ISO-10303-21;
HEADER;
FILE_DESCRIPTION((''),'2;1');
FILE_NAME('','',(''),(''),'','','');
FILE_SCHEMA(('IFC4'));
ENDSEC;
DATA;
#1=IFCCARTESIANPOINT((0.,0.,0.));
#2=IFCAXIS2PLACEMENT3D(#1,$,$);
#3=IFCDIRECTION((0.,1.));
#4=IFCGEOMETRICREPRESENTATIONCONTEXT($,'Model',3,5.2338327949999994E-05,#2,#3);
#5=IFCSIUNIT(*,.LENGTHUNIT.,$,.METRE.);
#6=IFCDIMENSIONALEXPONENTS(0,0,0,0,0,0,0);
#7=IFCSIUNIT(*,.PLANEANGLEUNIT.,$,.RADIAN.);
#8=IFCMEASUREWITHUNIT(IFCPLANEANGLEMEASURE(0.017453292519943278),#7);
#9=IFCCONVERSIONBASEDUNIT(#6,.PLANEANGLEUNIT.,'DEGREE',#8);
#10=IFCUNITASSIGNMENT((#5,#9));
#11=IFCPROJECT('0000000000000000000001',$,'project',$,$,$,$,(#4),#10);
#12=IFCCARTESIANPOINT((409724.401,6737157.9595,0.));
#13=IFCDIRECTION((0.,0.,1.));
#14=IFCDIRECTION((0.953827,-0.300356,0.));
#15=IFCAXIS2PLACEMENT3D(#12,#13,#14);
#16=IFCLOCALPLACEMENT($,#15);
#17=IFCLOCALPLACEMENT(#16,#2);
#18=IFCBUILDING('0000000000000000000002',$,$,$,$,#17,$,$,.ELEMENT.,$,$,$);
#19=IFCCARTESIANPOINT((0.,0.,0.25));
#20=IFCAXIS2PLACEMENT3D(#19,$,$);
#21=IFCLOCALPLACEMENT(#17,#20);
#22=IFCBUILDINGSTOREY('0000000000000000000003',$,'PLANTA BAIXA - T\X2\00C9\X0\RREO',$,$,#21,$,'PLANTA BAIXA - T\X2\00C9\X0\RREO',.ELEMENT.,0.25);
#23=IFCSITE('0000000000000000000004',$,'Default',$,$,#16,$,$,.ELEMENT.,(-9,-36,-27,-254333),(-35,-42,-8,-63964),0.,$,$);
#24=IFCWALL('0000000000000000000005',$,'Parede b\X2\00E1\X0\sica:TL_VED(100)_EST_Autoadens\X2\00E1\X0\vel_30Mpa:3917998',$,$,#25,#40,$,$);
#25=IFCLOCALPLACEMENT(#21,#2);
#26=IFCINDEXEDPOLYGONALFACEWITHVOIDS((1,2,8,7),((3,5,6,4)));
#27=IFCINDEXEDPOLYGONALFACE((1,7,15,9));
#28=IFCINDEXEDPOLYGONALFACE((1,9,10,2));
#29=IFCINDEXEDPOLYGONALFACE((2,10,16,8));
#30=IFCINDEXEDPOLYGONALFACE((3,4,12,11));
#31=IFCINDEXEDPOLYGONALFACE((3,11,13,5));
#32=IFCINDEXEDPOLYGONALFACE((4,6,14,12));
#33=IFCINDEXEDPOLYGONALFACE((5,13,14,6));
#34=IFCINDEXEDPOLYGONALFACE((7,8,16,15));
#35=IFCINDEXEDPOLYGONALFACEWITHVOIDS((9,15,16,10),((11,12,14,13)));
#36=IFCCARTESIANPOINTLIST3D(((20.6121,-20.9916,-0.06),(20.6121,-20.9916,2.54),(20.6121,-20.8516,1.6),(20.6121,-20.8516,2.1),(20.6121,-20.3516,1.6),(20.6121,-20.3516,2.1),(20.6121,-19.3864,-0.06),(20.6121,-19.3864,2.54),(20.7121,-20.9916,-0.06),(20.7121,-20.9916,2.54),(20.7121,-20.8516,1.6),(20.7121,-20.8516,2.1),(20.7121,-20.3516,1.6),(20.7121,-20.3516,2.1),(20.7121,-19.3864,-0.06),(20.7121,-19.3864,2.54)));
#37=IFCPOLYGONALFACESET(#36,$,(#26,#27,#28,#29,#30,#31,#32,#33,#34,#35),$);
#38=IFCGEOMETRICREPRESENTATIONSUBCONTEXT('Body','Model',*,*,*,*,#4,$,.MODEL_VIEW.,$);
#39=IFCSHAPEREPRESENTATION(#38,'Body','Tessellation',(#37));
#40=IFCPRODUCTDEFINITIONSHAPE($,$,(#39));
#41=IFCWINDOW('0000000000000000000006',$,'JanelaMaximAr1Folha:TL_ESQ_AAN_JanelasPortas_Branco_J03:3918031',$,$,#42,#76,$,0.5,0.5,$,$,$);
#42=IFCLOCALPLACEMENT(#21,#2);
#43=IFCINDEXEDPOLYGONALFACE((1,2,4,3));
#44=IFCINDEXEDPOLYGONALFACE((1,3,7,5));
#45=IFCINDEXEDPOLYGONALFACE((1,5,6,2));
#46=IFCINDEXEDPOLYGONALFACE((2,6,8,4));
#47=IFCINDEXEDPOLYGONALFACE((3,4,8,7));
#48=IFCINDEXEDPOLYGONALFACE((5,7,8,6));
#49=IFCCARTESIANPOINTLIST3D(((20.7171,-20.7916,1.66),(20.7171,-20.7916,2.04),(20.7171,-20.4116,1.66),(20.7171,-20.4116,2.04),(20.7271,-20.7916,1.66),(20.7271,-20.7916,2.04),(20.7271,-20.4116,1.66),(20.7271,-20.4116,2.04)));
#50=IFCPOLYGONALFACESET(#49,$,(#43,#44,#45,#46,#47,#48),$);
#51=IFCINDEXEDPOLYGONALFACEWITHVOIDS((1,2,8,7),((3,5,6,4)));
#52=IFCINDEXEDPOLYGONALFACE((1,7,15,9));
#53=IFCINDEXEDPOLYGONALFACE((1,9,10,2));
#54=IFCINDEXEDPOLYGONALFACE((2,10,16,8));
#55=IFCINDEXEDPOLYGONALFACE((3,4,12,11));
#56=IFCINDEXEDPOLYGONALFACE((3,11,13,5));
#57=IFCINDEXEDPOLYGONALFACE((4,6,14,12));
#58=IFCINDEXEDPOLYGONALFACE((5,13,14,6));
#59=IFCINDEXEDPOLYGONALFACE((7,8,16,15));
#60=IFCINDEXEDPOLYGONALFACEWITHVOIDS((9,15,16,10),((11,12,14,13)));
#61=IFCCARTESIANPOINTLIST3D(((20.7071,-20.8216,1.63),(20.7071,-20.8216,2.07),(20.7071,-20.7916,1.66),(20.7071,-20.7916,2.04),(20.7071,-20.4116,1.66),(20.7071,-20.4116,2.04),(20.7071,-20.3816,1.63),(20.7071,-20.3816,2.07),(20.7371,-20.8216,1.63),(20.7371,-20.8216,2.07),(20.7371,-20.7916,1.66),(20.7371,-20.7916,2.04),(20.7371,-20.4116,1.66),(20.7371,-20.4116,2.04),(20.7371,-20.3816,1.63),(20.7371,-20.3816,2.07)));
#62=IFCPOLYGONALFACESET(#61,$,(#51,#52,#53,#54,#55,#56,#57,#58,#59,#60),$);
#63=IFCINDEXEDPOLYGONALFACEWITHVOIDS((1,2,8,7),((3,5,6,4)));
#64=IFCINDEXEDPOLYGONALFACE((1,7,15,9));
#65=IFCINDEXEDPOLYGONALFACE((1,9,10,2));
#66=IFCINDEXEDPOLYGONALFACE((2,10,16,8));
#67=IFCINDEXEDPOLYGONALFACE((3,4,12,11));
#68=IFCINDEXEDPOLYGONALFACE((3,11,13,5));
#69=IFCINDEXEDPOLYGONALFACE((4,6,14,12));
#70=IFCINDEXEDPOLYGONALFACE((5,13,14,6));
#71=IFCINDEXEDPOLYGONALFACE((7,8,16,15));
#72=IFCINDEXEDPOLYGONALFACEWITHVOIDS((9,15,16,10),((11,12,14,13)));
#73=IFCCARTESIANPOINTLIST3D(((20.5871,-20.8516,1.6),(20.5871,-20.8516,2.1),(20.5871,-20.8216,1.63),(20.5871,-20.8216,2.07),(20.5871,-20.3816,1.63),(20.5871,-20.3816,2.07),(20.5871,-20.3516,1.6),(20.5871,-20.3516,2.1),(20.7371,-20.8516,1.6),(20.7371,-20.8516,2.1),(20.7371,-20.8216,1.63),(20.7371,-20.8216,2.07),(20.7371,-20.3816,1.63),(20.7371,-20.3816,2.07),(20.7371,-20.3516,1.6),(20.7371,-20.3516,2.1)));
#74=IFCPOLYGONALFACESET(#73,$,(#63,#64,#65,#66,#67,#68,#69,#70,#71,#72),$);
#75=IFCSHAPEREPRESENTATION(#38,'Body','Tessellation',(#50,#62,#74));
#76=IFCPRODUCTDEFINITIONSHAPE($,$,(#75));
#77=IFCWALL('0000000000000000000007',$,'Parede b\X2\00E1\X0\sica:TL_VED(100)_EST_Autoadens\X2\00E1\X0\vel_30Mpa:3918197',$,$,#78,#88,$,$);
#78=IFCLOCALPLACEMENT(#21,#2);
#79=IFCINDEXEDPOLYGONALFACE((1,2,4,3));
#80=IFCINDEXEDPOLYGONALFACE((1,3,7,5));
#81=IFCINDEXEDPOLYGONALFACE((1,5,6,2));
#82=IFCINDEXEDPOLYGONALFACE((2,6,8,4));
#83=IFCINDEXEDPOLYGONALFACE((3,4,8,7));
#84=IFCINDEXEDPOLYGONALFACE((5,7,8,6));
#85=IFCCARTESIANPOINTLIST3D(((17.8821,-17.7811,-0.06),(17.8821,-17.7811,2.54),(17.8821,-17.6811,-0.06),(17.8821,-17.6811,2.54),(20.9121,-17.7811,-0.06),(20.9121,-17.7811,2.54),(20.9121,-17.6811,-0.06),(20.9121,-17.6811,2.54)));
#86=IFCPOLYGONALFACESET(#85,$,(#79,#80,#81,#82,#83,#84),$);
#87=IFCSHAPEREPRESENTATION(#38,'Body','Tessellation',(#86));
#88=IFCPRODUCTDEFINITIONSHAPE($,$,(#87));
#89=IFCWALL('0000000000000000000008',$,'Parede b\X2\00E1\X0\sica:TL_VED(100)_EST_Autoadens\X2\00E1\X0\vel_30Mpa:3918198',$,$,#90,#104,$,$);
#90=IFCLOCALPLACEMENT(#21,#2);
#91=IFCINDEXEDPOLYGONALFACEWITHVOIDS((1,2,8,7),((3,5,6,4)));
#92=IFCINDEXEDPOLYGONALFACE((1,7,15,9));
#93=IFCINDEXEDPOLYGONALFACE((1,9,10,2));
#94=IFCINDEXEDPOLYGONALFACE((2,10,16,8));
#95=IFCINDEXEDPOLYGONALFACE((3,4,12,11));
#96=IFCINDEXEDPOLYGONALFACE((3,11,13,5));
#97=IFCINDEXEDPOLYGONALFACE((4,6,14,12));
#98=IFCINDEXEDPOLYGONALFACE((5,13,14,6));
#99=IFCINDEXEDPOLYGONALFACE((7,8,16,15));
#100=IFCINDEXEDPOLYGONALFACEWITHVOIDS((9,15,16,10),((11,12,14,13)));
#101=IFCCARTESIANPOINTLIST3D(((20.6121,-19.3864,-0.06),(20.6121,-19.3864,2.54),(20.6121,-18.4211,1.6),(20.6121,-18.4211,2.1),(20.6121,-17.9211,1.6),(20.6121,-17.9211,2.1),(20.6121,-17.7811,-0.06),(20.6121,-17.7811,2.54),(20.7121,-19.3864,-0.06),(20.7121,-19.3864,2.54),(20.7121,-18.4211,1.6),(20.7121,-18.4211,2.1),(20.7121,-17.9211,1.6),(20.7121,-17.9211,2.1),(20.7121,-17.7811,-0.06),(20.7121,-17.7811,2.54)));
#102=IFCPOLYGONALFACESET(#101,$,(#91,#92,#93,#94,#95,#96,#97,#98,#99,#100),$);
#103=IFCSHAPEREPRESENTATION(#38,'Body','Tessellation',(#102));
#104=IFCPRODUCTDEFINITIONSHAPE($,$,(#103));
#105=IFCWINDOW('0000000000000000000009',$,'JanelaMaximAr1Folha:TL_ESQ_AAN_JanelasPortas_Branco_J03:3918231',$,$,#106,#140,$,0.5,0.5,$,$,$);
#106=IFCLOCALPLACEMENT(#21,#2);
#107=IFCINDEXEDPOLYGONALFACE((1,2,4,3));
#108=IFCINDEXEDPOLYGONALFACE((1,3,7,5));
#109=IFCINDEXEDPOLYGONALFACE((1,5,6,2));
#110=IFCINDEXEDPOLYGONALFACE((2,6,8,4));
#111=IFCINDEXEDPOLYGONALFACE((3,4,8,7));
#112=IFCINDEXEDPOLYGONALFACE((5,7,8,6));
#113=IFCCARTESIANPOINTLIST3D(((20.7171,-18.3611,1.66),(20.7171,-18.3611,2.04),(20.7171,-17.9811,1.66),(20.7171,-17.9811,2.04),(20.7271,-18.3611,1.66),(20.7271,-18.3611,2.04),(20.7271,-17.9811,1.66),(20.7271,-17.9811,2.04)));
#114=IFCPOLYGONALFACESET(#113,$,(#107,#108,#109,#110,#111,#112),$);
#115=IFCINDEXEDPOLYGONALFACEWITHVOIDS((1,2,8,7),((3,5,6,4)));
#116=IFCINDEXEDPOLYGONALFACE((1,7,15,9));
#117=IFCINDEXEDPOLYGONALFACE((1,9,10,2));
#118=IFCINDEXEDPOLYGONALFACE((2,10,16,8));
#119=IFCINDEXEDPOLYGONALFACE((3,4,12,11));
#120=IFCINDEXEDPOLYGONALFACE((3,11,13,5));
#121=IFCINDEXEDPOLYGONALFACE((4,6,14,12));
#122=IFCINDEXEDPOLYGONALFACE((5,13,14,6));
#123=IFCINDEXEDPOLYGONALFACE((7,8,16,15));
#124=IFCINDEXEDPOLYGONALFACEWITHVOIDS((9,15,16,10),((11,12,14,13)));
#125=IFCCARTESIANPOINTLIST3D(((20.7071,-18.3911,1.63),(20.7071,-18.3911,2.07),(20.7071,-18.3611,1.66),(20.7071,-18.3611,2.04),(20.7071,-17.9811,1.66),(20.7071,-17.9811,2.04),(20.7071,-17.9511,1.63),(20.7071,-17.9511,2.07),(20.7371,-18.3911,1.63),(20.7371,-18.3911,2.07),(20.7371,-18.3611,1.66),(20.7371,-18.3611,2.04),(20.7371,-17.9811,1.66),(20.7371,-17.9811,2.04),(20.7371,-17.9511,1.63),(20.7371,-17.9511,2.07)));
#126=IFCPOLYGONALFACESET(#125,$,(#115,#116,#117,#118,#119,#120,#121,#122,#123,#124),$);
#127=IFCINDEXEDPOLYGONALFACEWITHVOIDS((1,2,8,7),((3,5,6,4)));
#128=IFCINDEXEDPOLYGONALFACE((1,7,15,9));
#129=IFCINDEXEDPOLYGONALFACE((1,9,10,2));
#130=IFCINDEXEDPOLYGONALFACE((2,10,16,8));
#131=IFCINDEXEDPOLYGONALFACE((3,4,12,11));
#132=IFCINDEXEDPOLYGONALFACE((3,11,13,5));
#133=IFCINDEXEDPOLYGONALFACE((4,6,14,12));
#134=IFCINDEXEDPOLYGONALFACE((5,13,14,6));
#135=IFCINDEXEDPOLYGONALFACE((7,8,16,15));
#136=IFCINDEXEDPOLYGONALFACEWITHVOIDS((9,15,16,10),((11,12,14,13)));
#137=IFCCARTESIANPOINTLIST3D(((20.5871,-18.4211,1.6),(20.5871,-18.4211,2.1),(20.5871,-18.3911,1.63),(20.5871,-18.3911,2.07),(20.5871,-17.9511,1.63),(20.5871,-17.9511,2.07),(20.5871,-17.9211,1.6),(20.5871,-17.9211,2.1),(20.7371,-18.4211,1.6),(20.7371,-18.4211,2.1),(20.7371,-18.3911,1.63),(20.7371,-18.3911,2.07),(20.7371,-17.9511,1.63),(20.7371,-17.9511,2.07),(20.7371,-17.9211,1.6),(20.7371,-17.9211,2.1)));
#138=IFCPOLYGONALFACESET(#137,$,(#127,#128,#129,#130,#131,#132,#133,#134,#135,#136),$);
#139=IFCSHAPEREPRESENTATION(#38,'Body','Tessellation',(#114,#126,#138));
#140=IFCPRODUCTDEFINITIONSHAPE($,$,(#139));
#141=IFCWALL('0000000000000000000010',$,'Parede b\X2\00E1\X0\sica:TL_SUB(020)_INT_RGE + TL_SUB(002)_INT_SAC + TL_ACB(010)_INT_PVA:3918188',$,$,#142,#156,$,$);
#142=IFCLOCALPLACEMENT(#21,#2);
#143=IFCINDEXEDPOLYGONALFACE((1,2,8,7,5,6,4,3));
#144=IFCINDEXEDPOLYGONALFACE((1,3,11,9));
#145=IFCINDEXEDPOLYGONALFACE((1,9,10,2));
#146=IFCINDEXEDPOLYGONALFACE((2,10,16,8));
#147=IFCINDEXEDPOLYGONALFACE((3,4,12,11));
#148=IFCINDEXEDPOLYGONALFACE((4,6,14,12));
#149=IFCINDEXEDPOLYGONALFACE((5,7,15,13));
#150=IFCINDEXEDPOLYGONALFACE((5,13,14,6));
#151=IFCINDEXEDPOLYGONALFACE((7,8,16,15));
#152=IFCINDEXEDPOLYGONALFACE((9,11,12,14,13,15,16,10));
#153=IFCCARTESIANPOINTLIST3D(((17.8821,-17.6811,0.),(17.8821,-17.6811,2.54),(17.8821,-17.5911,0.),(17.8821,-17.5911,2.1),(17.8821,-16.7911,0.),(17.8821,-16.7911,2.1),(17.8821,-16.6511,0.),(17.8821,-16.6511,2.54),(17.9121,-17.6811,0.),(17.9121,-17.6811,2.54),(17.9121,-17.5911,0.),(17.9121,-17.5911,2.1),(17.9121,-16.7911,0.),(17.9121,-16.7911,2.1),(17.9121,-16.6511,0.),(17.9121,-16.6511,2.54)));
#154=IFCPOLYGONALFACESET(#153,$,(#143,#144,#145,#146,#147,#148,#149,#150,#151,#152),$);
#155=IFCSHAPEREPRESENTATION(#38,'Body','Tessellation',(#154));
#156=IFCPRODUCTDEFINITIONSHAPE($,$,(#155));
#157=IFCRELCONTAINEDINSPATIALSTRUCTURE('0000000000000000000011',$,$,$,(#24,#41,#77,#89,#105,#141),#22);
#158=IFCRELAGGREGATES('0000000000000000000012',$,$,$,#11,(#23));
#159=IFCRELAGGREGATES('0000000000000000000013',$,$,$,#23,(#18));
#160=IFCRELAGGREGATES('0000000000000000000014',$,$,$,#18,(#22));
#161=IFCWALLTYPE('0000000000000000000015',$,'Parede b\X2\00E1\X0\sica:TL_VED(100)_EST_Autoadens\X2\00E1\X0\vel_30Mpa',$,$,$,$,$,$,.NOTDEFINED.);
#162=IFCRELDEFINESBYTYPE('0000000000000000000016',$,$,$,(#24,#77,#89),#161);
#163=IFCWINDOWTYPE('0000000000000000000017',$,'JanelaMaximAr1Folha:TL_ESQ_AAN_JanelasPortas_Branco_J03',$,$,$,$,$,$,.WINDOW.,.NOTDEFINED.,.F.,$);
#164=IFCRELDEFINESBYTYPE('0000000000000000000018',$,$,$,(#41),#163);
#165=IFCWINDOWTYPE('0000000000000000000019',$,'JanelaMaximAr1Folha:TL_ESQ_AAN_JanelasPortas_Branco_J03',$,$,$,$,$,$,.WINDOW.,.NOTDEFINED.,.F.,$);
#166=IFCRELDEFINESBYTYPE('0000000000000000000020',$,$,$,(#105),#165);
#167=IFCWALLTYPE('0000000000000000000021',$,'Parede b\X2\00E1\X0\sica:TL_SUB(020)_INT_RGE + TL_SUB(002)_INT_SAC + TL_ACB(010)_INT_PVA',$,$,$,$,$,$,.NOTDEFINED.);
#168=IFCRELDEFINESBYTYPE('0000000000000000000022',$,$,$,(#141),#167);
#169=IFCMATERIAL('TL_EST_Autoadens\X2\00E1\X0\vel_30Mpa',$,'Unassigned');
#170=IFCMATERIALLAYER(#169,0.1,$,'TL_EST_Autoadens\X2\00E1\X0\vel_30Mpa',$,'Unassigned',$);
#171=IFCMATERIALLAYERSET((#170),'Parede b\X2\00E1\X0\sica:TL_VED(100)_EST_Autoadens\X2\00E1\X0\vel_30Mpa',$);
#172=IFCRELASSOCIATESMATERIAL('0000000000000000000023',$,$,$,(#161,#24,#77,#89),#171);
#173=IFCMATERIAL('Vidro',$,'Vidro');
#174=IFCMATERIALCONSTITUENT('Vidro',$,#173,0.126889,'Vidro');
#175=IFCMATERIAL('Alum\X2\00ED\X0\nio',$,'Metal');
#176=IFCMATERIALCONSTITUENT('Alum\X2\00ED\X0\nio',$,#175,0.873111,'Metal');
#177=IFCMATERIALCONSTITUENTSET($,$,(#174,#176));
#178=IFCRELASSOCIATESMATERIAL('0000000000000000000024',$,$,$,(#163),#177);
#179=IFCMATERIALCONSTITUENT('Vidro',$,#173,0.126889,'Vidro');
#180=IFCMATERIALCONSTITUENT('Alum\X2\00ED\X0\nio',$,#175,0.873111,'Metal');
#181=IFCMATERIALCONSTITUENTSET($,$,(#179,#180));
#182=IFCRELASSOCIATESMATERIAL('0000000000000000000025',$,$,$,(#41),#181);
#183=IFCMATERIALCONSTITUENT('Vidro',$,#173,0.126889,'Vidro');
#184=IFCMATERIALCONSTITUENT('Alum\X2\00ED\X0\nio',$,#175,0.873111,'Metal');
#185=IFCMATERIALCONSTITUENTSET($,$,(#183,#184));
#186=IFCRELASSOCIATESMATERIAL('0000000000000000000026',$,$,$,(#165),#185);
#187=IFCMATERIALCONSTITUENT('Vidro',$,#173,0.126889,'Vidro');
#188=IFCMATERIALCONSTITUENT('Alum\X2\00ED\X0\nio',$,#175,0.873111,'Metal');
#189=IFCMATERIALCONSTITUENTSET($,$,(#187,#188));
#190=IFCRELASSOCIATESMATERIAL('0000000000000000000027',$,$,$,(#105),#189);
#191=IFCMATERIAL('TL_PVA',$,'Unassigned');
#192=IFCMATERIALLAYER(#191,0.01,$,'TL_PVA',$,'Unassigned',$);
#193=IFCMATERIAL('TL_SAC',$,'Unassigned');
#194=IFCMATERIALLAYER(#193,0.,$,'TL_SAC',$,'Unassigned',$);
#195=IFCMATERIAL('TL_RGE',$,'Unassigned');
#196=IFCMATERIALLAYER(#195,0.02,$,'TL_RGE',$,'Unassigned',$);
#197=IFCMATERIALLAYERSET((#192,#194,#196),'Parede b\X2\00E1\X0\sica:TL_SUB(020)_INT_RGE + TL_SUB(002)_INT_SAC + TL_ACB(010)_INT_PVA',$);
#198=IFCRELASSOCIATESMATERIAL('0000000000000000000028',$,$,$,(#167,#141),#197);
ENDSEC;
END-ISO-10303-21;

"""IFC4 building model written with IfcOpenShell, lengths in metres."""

from ifc_helpers import new_model, entity, si_unit, converted_unit, direction, frame, frame_2d, origin, place, context, subcontext, project, spatial, polyline, rectangle, outline, extrude, source, transform, mapped, material, layer, layer_set, layer_usage, constituent, constituent_set, type_object, type_shapes, element, fill, save


model = new_model("IFC4")

# Units and contexts
model_context = context("Model", 3, precision=5.2338327949999994e-05, world=origin(), true_north=direction((0.0, 1.0)))
body_context = subcontext(model_context, "Body", "Model", "MODEL_VIEW")
ifc_project = project(units=[si_unit("LENGTHUNIT", "METRE"), converted_unit("PLANEANGLEUNIT", "DEGREE", entity("IfcPlaneAngleMeasure", 0.017453292519943278), si_unit("PLANEANGLEUNIT", "RADIAN"), dimensions=[0, 0, 0, 0, 0, 0, 0])], contexts=[model_context])

# Site, building, storey
site_placement = place(None, frame((409724.401, 6737157.9595, 0.0), z_axis=(0.0, 0.0, 1.0), x_axis=(0.953827, -0.300356, 0.0)))
site = spatial("IfcSite", under=ifc_project, at=site_placement, Name="Default", CompositionType="ELEMENT", RefLatitude=(-9, -36, -27, -254333), RefLongitude=(-35, -42, -8, -63964), RefElevation=0.0)
building_placement = place(site_placement, origin())
building = spatial("IfcBuilding", under=site, at=building_placement, CompositionType="ELEMENT")
storey_placement = place(building_placement, frame((0.0, 0.0, 0.25)))
storey = spatial("IfcBuildingStorey", under=building, at=storey_placement, Name="PLANTA BAIXA - TÉRREO", LongName="PLANTA BAIXA - TÉRREO", CompositionType="ELEMENT", Elevation=0.25)

# Wall, opening, window
ifc_material_1 = material(Name="TL_EST_Autoadensável_30Mpa", Category="Unassigned")
ifc_layer_1 = layer(ifc_material_1, 0.1, Name="TL_EST_Autoadensável_30Mpa", Category="Unassigned")
ifc_layer_set_1 = layer_set([ifc_layer_1], Name="Parede básica:TL_VED(100)_EST_Autoadensável_30Mpa")
ifc_layer_usage_1 = layer_usage(ifc_layer_set_1, "AXIS2", "NEGATIVE", 0.05)
wall_type_1 = type_object("IfcWallType", Name="Parede básica:TL_VED(100)_EST_Autoadensável_30Mpa", PredefinedType="NOTDEFINED", material=ifc_layer_set_1)
wall_1_placement = place(storey_placement, frame((20.6621, -19.3864, -0.06), z_axis=(0.0, 0.0, 1.0), x_axis=(0.0, -1.0, 0.0)))
wall_1 = element("IfcWall", 1, at=wall_1_placement, inside=storey, type_object=wall_type_1, material=ifc_layer_usage_1, Name="Parede básica:TL_VED(100)_EST_Autoadensável_30Mpa:3917998", context=body_context, shape_type="SweptSolid", body=[
    extrude(rectangle(XDim=1.6052, YDim=0.1, at=frame_2d((0.8026, 0.0), x_axis=(-1.0, 0.0))), origin(), (0.0, 0.0, 1.0), 2.6),
])
opening_1_placement = place(wall_1_placement, frame((1.4652, 0.05, 1.66)))
opening_1 = element("IfcOpeningElement", 2, at=opening_1_placement, cuts=wall_1, PredefinedType="OPENING", context=body_context, shape_type="SweptSolid", body=[
    extrude(rectangle(XDim=0.5, YDim=0.5, at=frame_2d((0.25, 0.25), x_axis=(1.0, 0.0))), frame((0.0, 0.0, 0.0), z_axis=(0.0, -1.0, 0.0), x_axis=(0.0, 0.0, 1.0)), (0.0, 0.0, 1.0), 0.1),
])
ifc_material_2 = material(Name="Vidro", Category="Vidro")
ifc_constituent_1 = constituent(ifc_material_2, Name="Vidro", Category="Vidro", fraction=0.126889)
ifc_material_3 = material(Name="Alumínio", Category="Metal")
ifc_constituent_2 = constituent(ifc_material_3, Name="Alumínio", Category="Metal", fraction=0.873111)
ifc_constituent_set_1 = constituent_set(constituents=[ifc_constituent_1, ifc_constituent_2])
ifc_constituent_3 = constituent(ifc_material_2, Name="Vidro", Category="Vidro", fraction=0.126889)
ifc_constituent_4 = constituent(ifc_material_3, Name="Alumínio", Category="Metal", fraction=0.873111)
ifc_constituent_set_2 = constituent_set(constituents=[ifc_constituent_3, ifc_constituent_4])
window_type_1 = type_object("IfcWindowType", Name="JanelaMaximAr1Folha:TL_ESQ_AAN_JanelasPortas_Branco_J03", ParameterTakesPrecedence=False, PartitioningType="NOTDEFINED", PredefinedType="WINDOW", material=ifc_constituent_set_2)
shared_shape_1 = source(origin(), body_context, "Body", "SweptSolid", [
    extrude(rectangle(XDim=0.01, YDim=0.38, at=frame_2d((0.0, 0.0), x_axis=(1.0, 0.0))), frame((0.25, -0.01, 0.06), z_axis=(0.0, 0.0, 1.0), x_axis=(0.0, 1.0, 0.0)), (0.0, 0.0, 1.0), 0.38),
    extrude(outline(polyline([(-0.22, -0.22), (0.22, -0.22), (0.22, 0.22), (-0.22, 0.22), (-0.22, -0.22)]), holes=[polyline([(0.19, 0.19), (0.19, -0.19), (-0.19, -0.19), (-0.19, 0.19), (0.19, 0.19)])]), frame((0.25, -0.025, 0.25), z_axis=(0.0, 1.0, 0.0), x_axis=(0.0, 0.0, -1.0)), (0.0, 0.0, 1.0), 0.03),
    extrude(outline(polyline([(-0.25, -0.25), (0.25, -0.25), (0.25, 0.25), (-0.25, 0.25), (-0.25, -0.25)]), holes=[polyline([(-0.22, -0.22), (-0.22, 0.22), (0.22, 0.22), (0.22, -0.22), (-0.22, -0.22)])]), frame((0.25, -0.025, 0.25), z_axis=(0.0, 1.0, 0.0), x_axis=(0.0, 0.0, -1.0)), (0.0, 0.0, 1.0), 0.15),
])
type_shapes(window_type_1, [shared_shape_1])
window_1_placement = place(opening_1_placement, frame((0.0, 0.0, 0.0), z_axis=(0.0, 0.0, 1.0), x_axis=(-1.0, 0.0, 0.0)))
window_1 = element("IfcWindow", 3, at=window_1_placement, inside=storey, type_object=window_type_1, material=ifc_constituent_set_1, Name="JanelaMaximAr1Folha:TL_ESQ_AAN_JanelasPortas_Branco_J03:3918031", OverallHeight=0.5, OverallWidth=0.5, context=body_context, shape_type="MappedRepresentation", body=[
    mapped(shared_shape_1, transform((0.0, 0.0, 0.0), scale=1.0)),
])
fill(opening_1, window_1)

# Wall
ifc_layer_usage_2 = layer_usage(ifc_layer_set_1, "AXIS2", "POSITIVE", -0.05)
wall_2_placement = place(storey_placement, frame((17.8821, -17.7311, -0.06)))
element("IfcWall", 4, at=wall_2_placement, inside=storey, type_object=wall_type_1, material=ifc_layer_usage_2, Name="Parede básica:TL_VED(100)_EST_Autoadensável_30Mpa:3918197", context=body_context, shape_type="SweptSolid", body=[
    extrude(rectangle(XDim=3.03, YDim=0.1, at=frame_2d((1.515, 0.0), x_axis=(-1.0, 0.0))), origin(), (0.0, 0.0, 1.0), 2.6),
])

# Wall, opening, window
ifc_layer_usage_3 = layer_usage(ifc_layer_set_1, "AXIS2", "POSITIVE", -0.05)
wall_3_placement = place(storey_placement, frame((20.6621, -19.3864, -0.06), z_axis=(0.0, 0.0, 1.0), x_axis=(0.0, 1.0, 0.0)))
wall_3 = element("IfcWall", 5, at=wall_3_placement, inside=storey, type_object=wall_type_1, material=ifc_layer_usage_3, Name="Parede básica:TL_VED(100)_EST_Autoadensável_30Mpa:3918198", context=body_context, shape_type="SweptSolid", body=[
    extrude(rectangle(XDim=1.6052, YDim=0.1, at=frame_2d((0.8026, 0.0), x_axis=(-1.0, 0.0))), origin(), (0.0, 0.0, 1.0), 2.6),
])
opening_2_placement = place(wall_3_placement, frame((0.9652, -0.05, 1.66)))
opening_2 = element("IfcOpeningElement", 6, at=opening_2_placement, cuts=wall_3, PredefinedType="OPENING", context=body_context, shape_type="SweptSolid", body=[
    extrude(rectangle(XDim=0.5, YDim=0.5, at=frame_2d((0.25, 0.25), x_axis=(1.0, 0.0))), frame((0.0, 0.0, 0.0), z_axis=(0.0, 1.0, 0.0), x_axis=(0.0, 0.0, 1.0)), (0.0, 0.0, 1.0), 0.1),
])
ifc_constituent_5 = constituent(ifc_material_2, Name="Vidro", Category="Vidro", fraction=0.126889)
ifc_constituent_6 = constituent(ifc_material_3, Name="Alumínio", Category="Metal", fraction=0.873111)
ifc_constituent_set_3 = constituent_set(constituents=[ifc_constituent_5, ifc_constituent_6])
ifc_constituent_7 = constituent(ifc_material_2, Name="Vidro", Category="Vidro", fraction=0.126889)
ifc_constituent_8 = constituent(ifc_material_3, Name="Alumínio", Category="Metal", fraction=0.873111)
ifc_constituent_set_4 = constituent_set(constituents=[ifc_constituent_7, ifc_constituent_8])
window_type_2 = type_object("IfcWindowType", Name="JanelaMaximAr1Folha:TL_ESQ_AAN_JanelasPortas_Branco_J03", ParameterTakesPrecedence=False, PartitioningType="NOTDEFINED", PredefinedType="WINDOW", material=ifc_constituent_set_4)
shared_shape_2 = source(origin(), body_context, "Body", "SweptSolid", [
    extrude(rectangle(XDim=0.38, YDim=0.01, at=frame_2d((0.0, 0.0), x_axis=(1.0, 0.0))), frame((0.25, -0.01, 0.06)), (0.0, 0.0, 1.0), 0.38),
    extrude(outline(polyline([(-0.22, -0.22), (0.22, -0.22), (0.22, 0.22), (-0.22, 0.22), (-0.22, -0.22)]), holes=[polyline([(0.19, 0.19), (0.19, -0.19), (-0.19, -0.19), (-0.19, 0.19), (0.19, 0.19)])]), frame((0.25, 0.005, 0.25), z_axis=(0.0, -1.0, 0.0), x_axis=(0.0, 0.0, -1.0)), (0.0, 0.0, 1.0), 0.03),
    extrude(outline(polyline([(-0.25, -0.25), (0.25, -0.25), (0.25, 0.25), (-0.25, 0.25), (-0.25, -0.25)]), holes=[polyline([(-0.22, -0.22), (-0.22, 0.22), (0.22, 0.22), (0.22, -0.22), (-0.22, -0.22)])]), frame((0.25, 0.125, 0.25), z_axis=(0.0, -1.0, 0.0), x_axis=(0.0, 0.0, -1.0)), (0.0, 0.0, 1.0), 0.15),
])
type_shapes(window_type_2, [shared_shape_2])
window_2_placement = place(opening_2_placement, origin())
window_2 = element("IfcWindow", 7, at=window_2_placement, inside=storey, type_object=window_type_2, material=ifc_constituent_set_3, Name="JanelaMaximAr1Folha:TL_ESQ_AAN_JanelasPortas_Branco_J03:3918231", OverallHeight=0.5, OverallWidth=0.5, context=body_context, shape_type="MappedRepresentation", body=[
    mapped(shared_shape_2, transform((0.0, 0.0, 0.0), scale=1.0)),
])
fill(opening_2, window_2)

# Wall, opening
ifc_material_4 = material(Name="TL_PVA", Category="Unassigned")
ifc_layer_2 = layer(ifc_material_4, 0.01, Name="TL_PVA", Category="Unassigned")
ifc_material_5 = material(Name="TL_SAC", Category="Unassigned")
ifc_layer_3 = layer(ifc_material_5, 0.0, Name="TL_SAC", Category="Unassigned")
ifc_material_6 = material(Name="TL_RGE", Category="Unassigned")
ifc_layer_4 = layer(ifc_material_6, 0.02, Name="TL_RGE", Category="Unassigned")
ifc_layer_set_2 = layer_set([ifc_layer_2, ifc_layer_3, ifc_layer_4], Name="Parede básica:TL_SUB(020)_INT_RGE + TL_SUB(002)_INT_SAC + TL_ACB(010)_INT_PVA")
ifc_layer_usage_4 = layer_usage(ifc_layer_set_2, "AXIS2", "NEGATIVE", 0.015)
wall_type_2 = type_object("IfcWallType", Name="Parede básica:TL_SUB(020)_INT_RGE + TL_SUB(002)_INT_SAC + TL_ACB(010)_INT_PVA", PredefinedType="NOTDEFINED", material=ifc_layer_set_2)
wall_4_placement = place(storey_placement, frame((17.8971, -17.6811, 0.0), z_axis=(0.0, 0.0, 1.0), x_axis=(0.0, 1.0, 0.0)))
wall_4 = element("IfcWall", 8, at=wall_4_placement, inside=storey, type_object=wall_type_2, material=ifc_layer_usage_4, Name="Parede básica:TL_SUB(020)_INT_RGE + TL_SUB(002)_INT_SAC + TL_ACB(010)_INT_PVA:3918188", context=body_context, shape_type="SweptSolid", body=[
    extrude(rectangle(XDim=1.03, YDim=0.03, at=frame_2d((0.515, 0.0), x_axis=(-1.0, 0.0))), origin(), (0.0, 0.0, 1.0), 2.54),
])
opening_3_placement = place(wall_4_placement, frame((17.6811, 17.8971, 0.0)))
element("IfcOpeningElement", 9, at=opening_3_placement, cuts=wall_4, PredefinedType="OPENING", context=body_context, shape_type="SweptSolid", body=[
    extrude(rectangle(XDim=2.1, YDim=0.8, at=frame_2d((0.0, 0.0), x_axis=(1.0, 0.0))), frame((-17.1911, -19.4361, 1.05), z_axis=(0.0, 1.0, 0.0), x_axis=(0.0, 0.0, 1.0)), (0.0, 0.0, 1.0), 3.048),
])

save(model, "model.ifc")
